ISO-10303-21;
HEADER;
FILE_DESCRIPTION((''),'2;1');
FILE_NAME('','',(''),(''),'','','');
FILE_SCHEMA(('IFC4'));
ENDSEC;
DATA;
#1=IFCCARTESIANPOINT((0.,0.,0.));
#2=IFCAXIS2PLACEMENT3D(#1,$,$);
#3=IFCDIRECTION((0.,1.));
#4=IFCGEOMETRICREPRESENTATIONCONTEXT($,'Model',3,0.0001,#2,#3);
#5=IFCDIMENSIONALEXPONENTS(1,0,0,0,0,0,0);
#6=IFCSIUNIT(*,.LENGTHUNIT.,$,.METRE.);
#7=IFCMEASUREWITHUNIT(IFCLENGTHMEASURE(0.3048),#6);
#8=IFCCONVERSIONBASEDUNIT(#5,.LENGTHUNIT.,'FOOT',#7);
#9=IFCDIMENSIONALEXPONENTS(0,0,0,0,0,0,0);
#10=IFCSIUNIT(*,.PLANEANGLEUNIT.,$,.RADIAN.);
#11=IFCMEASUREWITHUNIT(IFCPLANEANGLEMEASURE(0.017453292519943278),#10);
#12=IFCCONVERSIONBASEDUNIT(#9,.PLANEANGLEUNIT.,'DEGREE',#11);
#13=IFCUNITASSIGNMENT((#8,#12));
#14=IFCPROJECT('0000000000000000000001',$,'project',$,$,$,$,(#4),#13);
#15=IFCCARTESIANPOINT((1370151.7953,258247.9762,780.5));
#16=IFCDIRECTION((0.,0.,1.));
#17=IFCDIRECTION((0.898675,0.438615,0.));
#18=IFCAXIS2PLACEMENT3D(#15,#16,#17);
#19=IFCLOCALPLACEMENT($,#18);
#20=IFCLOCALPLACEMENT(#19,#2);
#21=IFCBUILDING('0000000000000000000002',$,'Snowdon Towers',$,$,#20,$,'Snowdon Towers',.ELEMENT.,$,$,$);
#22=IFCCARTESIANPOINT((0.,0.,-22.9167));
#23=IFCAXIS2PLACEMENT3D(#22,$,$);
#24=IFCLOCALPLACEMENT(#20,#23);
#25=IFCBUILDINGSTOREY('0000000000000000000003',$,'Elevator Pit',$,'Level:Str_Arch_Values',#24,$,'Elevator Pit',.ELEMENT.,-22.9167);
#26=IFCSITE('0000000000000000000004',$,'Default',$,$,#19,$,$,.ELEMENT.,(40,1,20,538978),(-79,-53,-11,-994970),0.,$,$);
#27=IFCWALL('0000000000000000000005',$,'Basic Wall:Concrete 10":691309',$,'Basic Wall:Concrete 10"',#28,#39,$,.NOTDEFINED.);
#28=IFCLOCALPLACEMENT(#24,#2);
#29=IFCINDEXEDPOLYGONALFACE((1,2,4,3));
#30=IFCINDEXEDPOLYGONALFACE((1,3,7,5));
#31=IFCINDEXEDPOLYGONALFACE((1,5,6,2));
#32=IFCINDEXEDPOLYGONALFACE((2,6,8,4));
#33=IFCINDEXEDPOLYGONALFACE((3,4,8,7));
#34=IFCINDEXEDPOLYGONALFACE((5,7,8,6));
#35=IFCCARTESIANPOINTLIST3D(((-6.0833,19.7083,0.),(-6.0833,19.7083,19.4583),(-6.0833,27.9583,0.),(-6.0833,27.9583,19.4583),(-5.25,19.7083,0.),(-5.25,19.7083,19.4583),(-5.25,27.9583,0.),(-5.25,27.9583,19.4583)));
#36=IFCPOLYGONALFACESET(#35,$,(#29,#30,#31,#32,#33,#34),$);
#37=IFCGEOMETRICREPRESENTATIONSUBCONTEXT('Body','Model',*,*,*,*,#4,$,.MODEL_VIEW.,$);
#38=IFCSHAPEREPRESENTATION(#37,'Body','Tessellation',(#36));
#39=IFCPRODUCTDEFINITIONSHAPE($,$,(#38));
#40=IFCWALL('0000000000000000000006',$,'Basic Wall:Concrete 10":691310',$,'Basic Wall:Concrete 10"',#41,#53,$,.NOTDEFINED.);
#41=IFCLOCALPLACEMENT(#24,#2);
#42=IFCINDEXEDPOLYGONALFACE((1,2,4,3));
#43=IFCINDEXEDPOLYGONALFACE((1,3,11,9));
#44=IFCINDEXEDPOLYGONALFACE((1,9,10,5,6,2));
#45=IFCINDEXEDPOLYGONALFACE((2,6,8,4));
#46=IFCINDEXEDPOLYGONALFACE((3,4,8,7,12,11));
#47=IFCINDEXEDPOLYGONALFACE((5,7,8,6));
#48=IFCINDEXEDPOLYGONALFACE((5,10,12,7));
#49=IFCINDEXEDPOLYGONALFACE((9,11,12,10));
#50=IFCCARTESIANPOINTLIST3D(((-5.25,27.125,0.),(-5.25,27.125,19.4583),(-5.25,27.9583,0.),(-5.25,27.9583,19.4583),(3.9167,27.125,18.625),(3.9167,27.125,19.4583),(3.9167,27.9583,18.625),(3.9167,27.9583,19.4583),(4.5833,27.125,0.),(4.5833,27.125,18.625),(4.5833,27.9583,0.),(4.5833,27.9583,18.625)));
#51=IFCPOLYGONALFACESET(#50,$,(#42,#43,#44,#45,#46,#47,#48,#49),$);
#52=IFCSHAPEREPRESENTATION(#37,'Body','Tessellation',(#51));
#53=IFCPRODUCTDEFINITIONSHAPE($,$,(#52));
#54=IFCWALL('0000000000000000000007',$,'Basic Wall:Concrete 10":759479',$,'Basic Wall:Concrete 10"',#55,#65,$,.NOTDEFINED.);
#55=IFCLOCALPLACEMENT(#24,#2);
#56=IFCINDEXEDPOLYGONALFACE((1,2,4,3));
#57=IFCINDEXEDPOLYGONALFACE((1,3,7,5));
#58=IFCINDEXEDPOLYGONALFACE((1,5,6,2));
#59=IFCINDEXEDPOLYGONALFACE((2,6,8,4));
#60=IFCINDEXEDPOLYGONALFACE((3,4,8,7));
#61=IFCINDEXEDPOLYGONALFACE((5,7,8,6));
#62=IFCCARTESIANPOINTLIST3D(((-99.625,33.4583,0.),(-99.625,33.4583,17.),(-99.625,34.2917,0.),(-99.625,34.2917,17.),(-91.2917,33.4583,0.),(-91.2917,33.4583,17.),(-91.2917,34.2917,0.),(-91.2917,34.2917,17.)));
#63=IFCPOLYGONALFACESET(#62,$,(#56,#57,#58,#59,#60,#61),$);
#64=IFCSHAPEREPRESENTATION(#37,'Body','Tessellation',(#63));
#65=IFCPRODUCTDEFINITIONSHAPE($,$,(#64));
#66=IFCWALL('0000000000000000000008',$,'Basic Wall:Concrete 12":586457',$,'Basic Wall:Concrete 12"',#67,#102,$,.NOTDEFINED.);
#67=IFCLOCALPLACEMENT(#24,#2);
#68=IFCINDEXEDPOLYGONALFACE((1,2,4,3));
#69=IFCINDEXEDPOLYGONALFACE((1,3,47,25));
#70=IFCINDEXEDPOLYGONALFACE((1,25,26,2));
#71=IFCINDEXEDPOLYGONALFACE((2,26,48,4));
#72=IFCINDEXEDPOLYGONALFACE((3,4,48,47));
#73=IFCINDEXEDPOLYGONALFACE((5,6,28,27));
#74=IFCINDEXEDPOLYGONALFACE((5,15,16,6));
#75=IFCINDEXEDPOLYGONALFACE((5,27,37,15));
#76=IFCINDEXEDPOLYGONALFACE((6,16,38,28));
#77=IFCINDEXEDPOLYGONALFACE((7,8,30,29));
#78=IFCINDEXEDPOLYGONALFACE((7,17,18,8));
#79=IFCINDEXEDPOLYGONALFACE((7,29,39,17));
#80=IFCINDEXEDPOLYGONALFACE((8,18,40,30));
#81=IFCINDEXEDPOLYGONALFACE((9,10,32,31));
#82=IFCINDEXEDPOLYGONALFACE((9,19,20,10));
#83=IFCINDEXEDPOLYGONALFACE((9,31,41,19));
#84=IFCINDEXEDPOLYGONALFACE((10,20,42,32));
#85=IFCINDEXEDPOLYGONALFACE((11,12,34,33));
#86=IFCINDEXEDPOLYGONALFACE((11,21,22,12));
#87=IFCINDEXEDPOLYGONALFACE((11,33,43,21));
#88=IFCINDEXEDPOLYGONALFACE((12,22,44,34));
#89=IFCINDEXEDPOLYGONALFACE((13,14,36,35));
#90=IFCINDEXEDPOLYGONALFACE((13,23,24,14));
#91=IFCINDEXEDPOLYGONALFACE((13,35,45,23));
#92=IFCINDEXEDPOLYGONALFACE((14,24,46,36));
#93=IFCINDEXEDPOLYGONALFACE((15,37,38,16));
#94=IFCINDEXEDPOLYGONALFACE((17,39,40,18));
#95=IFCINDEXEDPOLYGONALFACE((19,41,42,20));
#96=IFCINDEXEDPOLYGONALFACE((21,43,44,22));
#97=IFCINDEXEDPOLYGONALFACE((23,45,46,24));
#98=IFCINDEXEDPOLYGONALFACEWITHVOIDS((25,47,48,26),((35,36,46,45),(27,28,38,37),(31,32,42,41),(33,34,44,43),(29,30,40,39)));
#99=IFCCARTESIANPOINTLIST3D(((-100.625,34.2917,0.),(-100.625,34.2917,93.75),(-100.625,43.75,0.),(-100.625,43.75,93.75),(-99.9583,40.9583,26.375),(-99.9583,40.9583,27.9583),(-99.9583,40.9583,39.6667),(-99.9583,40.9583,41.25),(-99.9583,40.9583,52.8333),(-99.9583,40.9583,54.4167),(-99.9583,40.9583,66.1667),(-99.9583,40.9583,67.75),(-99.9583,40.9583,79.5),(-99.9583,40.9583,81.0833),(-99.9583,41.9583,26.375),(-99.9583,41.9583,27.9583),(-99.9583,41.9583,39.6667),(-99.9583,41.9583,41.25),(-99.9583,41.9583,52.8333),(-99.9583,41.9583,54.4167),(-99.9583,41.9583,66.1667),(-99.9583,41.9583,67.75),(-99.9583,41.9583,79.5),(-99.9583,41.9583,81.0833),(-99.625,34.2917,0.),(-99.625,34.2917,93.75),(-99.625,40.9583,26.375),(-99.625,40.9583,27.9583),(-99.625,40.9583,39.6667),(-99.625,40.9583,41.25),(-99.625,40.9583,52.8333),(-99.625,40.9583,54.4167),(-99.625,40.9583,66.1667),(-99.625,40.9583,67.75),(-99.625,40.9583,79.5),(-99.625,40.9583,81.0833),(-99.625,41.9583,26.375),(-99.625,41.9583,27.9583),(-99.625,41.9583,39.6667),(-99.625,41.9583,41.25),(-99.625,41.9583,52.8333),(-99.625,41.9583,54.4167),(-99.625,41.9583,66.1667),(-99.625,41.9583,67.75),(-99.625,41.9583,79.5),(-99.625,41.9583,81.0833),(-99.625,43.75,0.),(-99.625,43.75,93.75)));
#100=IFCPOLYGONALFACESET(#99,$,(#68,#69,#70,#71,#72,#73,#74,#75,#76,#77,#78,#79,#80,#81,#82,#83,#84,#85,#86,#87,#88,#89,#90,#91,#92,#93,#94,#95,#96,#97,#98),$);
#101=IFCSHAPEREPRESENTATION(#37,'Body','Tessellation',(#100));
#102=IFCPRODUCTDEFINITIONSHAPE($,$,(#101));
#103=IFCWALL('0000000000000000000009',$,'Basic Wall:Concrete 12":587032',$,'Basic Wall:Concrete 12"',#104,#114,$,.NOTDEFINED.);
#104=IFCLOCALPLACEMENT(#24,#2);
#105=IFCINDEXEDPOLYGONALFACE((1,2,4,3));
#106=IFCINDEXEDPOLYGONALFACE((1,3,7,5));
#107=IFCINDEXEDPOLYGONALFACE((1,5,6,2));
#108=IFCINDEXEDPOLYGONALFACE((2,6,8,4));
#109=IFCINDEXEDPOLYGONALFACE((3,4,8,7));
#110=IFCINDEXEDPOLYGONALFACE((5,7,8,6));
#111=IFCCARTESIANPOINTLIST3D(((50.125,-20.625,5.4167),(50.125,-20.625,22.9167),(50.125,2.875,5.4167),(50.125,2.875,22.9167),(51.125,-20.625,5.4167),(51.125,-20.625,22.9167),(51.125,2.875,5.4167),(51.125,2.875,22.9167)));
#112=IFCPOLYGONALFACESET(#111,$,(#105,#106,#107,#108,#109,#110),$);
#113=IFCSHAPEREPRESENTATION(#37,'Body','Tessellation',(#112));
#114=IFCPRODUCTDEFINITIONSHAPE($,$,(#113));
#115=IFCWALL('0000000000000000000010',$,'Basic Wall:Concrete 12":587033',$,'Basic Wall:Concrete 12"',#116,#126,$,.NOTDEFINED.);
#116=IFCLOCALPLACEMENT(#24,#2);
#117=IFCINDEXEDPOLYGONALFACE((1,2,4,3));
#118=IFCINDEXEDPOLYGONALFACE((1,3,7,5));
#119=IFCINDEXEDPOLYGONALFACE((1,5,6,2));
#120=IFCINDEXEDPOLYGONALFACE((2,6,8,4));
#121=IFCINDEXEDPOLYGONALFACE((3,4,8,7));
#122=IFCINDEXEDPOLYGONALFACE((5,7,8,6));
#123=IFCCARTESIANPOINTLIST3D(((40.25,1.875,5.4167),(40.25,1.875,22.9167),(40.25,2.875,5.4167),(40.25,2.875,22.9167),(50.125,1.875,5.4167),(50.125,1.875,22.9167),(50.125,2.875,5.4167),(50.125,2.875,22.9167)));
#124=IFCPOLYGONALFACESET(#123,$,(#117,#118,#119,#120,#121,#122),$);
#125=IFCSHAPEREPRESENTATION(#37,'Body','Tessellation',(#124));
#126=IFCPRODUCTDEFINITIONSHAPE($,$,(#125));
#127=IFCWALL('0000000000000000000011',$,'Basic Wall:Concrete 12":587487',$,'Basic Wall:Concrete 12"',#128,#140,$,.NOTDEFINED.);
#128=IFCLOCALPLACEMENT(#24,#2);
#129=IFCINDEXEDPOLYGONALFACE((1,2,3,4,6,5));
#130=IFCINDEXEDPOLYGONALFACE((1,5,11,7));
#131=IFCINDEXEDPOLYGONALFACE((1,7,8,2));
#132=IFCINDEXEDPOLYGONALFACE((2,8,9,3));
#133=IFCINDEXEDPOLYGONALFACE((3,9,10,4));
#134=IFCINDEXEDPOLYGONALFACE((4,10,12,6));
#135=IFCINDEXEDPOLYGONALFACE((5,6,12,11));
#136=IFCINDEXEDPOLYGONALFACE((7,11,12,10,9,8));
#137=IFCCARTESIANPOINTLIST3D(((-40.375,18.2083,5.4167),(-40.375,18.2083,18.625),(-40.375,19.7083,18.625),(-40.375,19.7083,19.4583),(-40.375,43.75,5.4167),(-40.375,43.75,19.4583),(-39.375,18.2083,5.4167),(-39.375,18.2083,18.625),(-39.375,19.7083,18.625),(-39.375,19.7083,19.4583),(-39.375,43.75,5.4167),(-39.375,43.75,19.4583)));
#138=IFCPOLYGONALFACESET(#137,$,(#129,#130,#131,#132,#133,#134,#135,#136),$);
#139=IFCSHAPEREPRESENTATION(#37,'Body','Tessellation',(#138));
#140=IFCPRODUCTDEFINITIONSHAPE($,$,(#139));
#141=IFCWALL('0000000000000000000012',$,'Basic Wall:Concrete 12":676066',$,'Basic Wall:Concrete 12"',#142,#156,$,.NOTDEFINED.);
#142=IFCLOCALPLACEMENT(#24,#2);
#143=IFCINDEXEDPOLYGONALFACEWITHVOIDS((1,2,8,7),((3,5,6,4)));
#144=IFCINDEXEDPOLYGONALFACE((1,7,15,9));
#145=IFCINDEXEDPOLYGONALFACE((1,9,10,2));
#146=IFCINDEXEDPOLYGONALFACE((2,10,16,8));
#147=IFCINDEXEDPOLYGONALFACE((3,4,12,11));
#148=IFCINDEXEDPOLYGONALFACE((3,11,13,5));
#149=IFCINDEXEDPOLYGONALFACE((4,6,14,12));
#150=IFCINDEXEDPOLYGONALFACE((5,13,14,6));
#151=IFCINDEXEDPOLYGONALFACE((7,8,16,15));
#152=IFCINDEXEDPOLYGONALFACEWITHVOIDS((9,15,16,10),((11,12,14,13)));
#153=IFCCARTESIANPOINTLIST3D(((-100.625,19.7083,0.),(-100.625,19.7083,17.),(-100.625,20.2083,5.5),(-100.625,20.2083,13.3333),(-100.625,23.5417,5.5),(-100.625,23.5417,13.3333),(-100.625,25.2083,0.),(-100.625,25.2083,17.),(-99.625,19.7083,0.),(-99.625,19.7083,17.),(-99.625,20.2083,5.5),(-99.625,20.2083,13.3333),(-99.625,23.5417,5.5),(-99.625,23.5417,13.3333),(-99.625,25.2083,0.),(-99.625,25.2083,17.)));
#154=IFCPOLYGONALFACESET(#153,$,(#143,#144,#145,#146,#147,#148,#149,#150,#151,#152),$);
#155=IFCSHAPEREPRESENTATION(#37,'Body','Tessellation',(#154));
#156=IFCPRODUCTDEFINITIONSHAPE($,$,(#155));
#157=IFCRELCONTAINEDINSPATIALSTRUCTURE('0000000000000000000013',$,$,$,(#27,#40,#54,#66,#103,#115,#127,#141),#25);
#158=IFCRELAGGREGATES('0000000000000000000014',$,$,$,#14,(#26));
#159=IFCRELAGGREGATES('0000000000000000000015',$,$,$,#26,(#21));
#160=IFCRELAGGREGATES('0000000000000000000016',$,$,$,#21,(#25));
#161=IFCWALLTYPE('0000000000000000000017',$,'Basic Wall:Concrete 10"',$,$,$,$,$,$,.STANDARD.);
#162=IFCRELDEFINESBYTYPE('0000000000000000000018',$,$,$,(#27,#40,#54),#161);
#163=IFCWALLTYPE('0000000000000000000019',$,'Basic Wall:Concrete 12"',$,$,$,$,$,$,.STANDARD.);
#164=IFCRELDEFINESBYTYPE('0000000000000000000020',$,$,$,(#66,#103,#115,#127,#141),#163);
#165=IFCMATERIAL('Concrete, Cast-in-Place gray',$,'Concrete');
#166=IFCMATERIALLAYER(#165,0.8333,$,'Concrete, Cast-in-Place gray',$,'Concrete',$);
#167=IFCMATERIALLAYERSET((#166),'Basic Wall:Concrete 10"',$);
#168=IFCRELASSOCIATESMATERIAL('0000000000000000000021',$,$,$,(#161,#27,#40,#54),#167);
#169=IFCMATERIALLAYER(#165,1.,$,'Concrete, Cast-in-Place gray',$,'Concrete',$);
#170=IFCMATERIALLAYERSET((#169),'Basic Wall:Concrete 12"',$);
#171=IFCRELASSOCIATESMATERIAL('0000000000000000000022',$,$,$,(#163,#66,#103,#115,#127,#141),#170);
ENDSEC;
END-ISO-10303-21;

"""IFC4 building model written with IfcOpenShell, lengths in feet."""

from ifc_helpers import new_model, entity, si_unit, converted_unit, direction, frame, frame_2d, origin, origin_2d_with_axis, place, context, subcontext, project, spatial, polyline, rectangle, extrude, clip, bounded_halfspace, material, layer, layer_set, layer_usage, type_object, element, save


model = new_model("IFC4")

# Units and contexts
model_context = context("Model", 3, precision=0.0001, world=origin(), true_north=direction((0.0, 1.0)))
body_context = subcontext(model_context, "Body", "Model", "MODEL_VIEW")
ifc_project = project(units=[converted_unit("LENGTHUNIT", "FOOT", entity("IfcLengthMeasure", 0.3048), si_unit("LENGTHUNIT", "METRE"), dimensions=[1, 0, 0, 0, 0, 0, 0]), converted_unit("PLANEANGLEUNIT", "DEGREE", entity("IfcPlaneAngleMeasure", 0.017453292519943278), si_unit("PLANEANGLEUNIT", "RADIAN"), dimensions=[0, 0, 0, 0, 0, 0, 0])], contexts=[model_context])

# Site, building, storey
site_placement = place(None, frame((1370151.7953, 258247.9762, 780.5), z_axis=(0.0, 0.0, 1.0), x_axis=(0.898675, 0.438615, 0.0)))
site = spatial("IfcSite", under=ifc_project, at=site_placement, Name="Default", CompositionType="ELEMENT", RefLatitude=(40, 1, 20, 538978), RefLongitude=(-79, -53, -11, -994970), RefElevation=0.0)
building_placement = place(site_placement, origin())
building = spatial("IfcBuilding", under=site, at=building_placement, Name="Snowdon Towers", LongName="Snowdon Towers", CompositionType="ELEMENT")
storey_placement = place(building_placement, frame((0.0, 0.0, -22.9167)))
storey = spatial("IfcBuildingStorey", under=building, at=storey_placement, Name="Elevator Pit", ObjectType="Level:Str_Arch_Values", LongName="Elevator Pit", CompositionType="ELEMENT", Elevation=-22.9167)

# Shared definitions
ifc_material = material(Name="Concrete, Cast-in-Place gray", Category="Concrete")
ifc_layer_1 = layer(ifc_material, 0.8333, Name="Concrete, Cast-in-Place gray", Category="Concrete")
ifc_layer_set_1 = layer_set([ifc_layer_1], Name="Basic Wall:Concrete 10\"")
wall_type_1 = type_object("IfcWallType", Name="Basic Wall:Concrete 10\"", PredefinedType="STANDARD", material=ifc_layer_set_1)

# Walls
ifc_layer_usage_1 = layer_usage(ifc_layer_set_1, "AXIS2", "NEGATIVE", 0.4167)
wall_1_placement = place(storey_placement, frame((-5.6667, 27.9583, 0.0), z_axis=(0.0, 0.0, 1.0), x_axis=(0.0, -1.0, 0.0)))
element("IfcWall", 1, at=wall_1_placement, inside=storey, type_object=wall_type_1, material=ifc_layer_usage_1, Name="Basic Wall:Concrete 10\":691309", ObjectType="Basic Wall:Concrete 10\"", PredefinedType="NOTDEFINED", context=body_context, shape_type="SweptSolid", body=[
    extrude(rectangle(XDim=8.25, YDim=0.8333, at=frame_2d((4.125, 0.0), x_axis=(-1.0, 0.0))), origin(), (0.0, 0.0, 1.0), 19.4583),
])
ifc_layer_usage_2 = layer_usage(ifc_layer_set_1, "AXIS2", "NEGATIVE", 0.4167)
wall_2_placement = place(storey_placement, frame((4.5833, 27.5417, 0.0), z_axis=(0.0, 0.0, 1.0), x_axis=(-1.0, 0.0, 0.0)))
element("IfcWall", 2, at=wall_2_placement, inside=storey, type_object=wall_type_1, material=ifc_layer_usage_2, Name="Basic Wall:Concrete 10\":691310", ObjectType="Basic Wall:Concrete 10\"", PredefinedType="NOTDEFINED", context=body_context, shape_type="Clipping", body=[
    clip(clip(extrude(rectangle(XDim=9.8333, YDim=0.8333, at=frame_2d((4.9167, 0.0), x_axis=(-1.0, 0.0))), origin(), (0.0, 0.0, 1.0), 19.4583), bounded_halfspace(frame((0.6667, -0.4167, 18.625), z_axis=(0.0, 0.0, -1.0), x_axis=(1.0, 0.0, 0.0)), True, frame((0.6667, -0.4167, 18.625), z_axis=(0.0, 0.0, -1.0), x_axis=(1.0, 0.0, 0.0)), polyline([(0.0, 0.0), (-0.6667, 0.0), (-0.6667, -0.8333), (0.0, -0.8333), (0.0, 0.0)]))), bounded_halfspace(frame((0.6667, 0.4167, 18.625), z_axis=(1.0, 0.0, 0.0), x_axis=(0.0, 0.0, 1.0)), True, frame((0.6667, 0.4167, 18.625), z_axis=(1.0, 0.0, 0.0), x_axis=(0.0, 0.0, 1.0)), polyline([(0.0, 0.0), (0.8333, 0.0), (0.8333, 0.8333), (0.0, 0.8333), (0.0, 0.0)]))),
])
ifc_layer_usage_3 = layer_usage(ifc_layer_set_1, "AXIS2", "POSITIVE", -0.4167)
wall_3_placement = place(storey_placement, frame((-99.625, 33.875, 0.0)))
element("IfcWall", 3, at=wall_3_placement, inside=storey, type_object=wall_type_1, material=ifc_layer_usage_3, Name="Basic Wall:Concrete 10\":759479", ObjectType="Basic Wall:Concrete 10\"", PredefinedType="NOTDEFINED", context=body_context, shape_type="SweptSolid", body=[
    extrude(rectangle(XDim=8.3333, YDim=0.8333, at=frame_2d((4.1667, 0.0), x_axis=(-1.0, 0.0))), origin(), (0.0, 0.0, 1.0), 17.0),
])

# Wall, openings
ifc_layer_2 = layer(ifc_material, 1.0, Name="Concrete, Cast-in-Place gray", Category="Concrete")
ifc_layer_set_2 = layer_set([ifc_layer_2], Name="Basic Wall:Concrete 12\"")
ifc_layer_usage_4 = layer_usage(ifc_layer_set_2, "AXIS2", "NEGATIVE", 0.5)
wall_type_2 = type_object("IfcWallType", Name="Basic Wall:Concrete 12\"", PredefinedType="STANDARD", material=ifc_layer_set_2)
wall_4_placement = place(storey_placement, frame((-100.125, 34.2917, 0.0), z_axis=(0.0, 0.0, 1.0), x_axis=(0.0, 1.0, 0.0)))
wall_4 = element("IfcWall", 4, at=wall_4_placement, inside=storey, type_object=wall_type_2, material=ifc_layer_usage_4, Name="Basic Wall:Concrete 12\":586457", ObjectType="Basic Wall:Concrete 12\"", PredefinedType="NOTDEFINED", context=body_context, shape_type="SweptSolid", body=[
    extrude(rectangle(XDim=9.4583, YDim=1.0, at=frame_2d((4.7292, 0.0), x_axis=(-1.0, 0.0))), origin(), (0.0, 0.0, 1.0), 93.75),
])
opening_1_placement = place(wall_4_placement, origin())
element("IfcOpeningElement", 5, at=opening_1_placement, cuts=wall_4, PredefinedType="RECESS", context=body_context, shape_type="SweptSolid", body=[
    extrude(rectangle(XDim=1.5833, YDim=1.0, at=frame_2d((0.0, 0.0), x_axis=(1.0, 0.0))), frame((7.1667, -0.5, 40.4583), z_axis=(0.0, 1.0, 0.0), x_axis=(0.0, 0.0, -1.0)), (0.0, 0.0, 1.0), 0.3333),
])
opening_2_placement = place(wall_4_placement, origin())
element("IfcOpeningElement", 6, at=opening_2_placement, cuts=wall_4, PredefinedType="RECESS", context=body_context, shape_type="SweptSolid", body=[
    extrude(rectangle(XDim=1.5833, YDim=1.0, at=frame_2d((0.0, 0.0), x_axis=(1.0, 0.0))), frame((7.1667, -0.5, 27.1667), z_axis=(0.0, 1.0, 0.0), x_axis=(0.0, 0.0, -1.0)), (0.0, 0.0, 1.0), 0.3333),
])
opening_3_placement = place(wall_4_placement, origin())
element("IfcOpeningElement", 7, at=opening_3_placement, cuts=wall_4, PredefinedType="RECESS", context=body_context, shape_type="SweptSolid", body=[
    extrude(rectangle(XDim=1.5833, YDim=1.0, at=frame_2d((0.0, 0.0), x_axis=(1.0, 0.0))), frame((7.1667, -0.5, 80.2917), z_axis=(0.0, 1.0, 0.0), x_axis=(0.0, 0.0, -1.0)), (0.0, 0.0, 1.0), 0.3333),
])
opening_4_placement = place(wall_4_placement, origin())
element("IfcOpeningElement", 8, at=opening_4_placement, cuts=wall_4, PredefinedType="RECESS", context=body_context, shape_type="SweptSolid", body=[
    extrude(rectangle(XDim=1.5833, YDim=1.0, at=frame_2d((0.0, 0.0), x_axis=(1.0, 0.0))), frame((7.1667, -0.5, 53.625), z_axis=(0.0, 1.0, 0.0), x_axis=(0.0, 0.0, -1.0)), (0.0, 0.0, 1.0), 0.3333),
])
opening_5_placement = place(wall_4_placement, origin())
element("IfcOpeningElement", 9, at=opening_5_placement, cuts=wall_4, PredefinedType="RECESS", context=body_context, shape_type="SweptSolid", body=[
    extrude(rectangle(XDim=1.5833, YDim=1.0, at=origin_2d_with_axis()), frame((7.1667, -0.5, 66.9583), z_axis=(0.0, 1.0, 0.0), x_axis=(0.0, 0.0, -1.0)), (0.0, 0.0, 1.0), 0.3333),
])

# Walls
ifc_layer_usage_5 = layer_usage(ifc_layer_set_2, "AXIS2", "NEGATIVE", 0.5)
wall_5_placement = place(storey_placement, frame((50.625, -20.625, 5.4167), z_axis=(0.0, 0.0, 1.0), x_axis=(0.0, 1.0, 0.0)))
element("IfcWall", 10, at=wall_5_placement, inside=storey, type_object=wall_type_2, material=ifc_layer_usage_5, Name="Basic Wall:Concrete 12\":587032", ObjectType="Basic Wall:Concrete 12\"", PredefinedType="NOTDEFINED", context=body_context, shape_type="SweptSolid", body=[
    extrude(rectangle(XDim=23.5, YDim=1.0, at=frame_2d((11.75, 0.0), x_axis=(-1.0, 0.0))), origin(), (0.0, 0.0, 1.0), 17.5),
])
ifc_layer_usage_6 = layer_usage(ifc_layer_set_2, "AXIS2", "NEGATIVE", 0.5)
wall_6_placement = place(storey_placement, frame((50.125, 2.375, 5.4167), z_axis=(0.0, 0.0, 1.0), x_axis=(-1.0, 0.0, 0.0)))
element("IfcWall", 11, at=wall_6_placement, inside=storey, type_object=wall_type_2, material=ifc_layer_usage_6, Name="Basic Wall:Concrete 12\":587033", ObjectType="Basic Wall:Concrete 12\"", PredefinedType="NOTDEFINED", context=body_context, shape_type="SweptSolid", body=[
    extrude(rectangle(XDim=9.875, YDim=1.0, at=frame_2d((4.9375, 0.0), x_axis=(-1.0, 0.0))), origin(), (0.0, 0.0, 1.0), 17.5),
])
ifc_layer_usage_7 = layer_usage(ifc_layer_set_2, "AXIS2", "NEGATIVE", 0.5)
wall_7_placement = place(storey_placement, frame((-39.875, 18.2083, 5.4167), z_axis=(0.0, 0.0, 1.0), x_axis=(0.0, 1.0, 0.0)))
element("IfcWall", 12, at=wall_7_placement, inside=storey, type_object=wall_type_2, material=ifc_layer_usage_7, Name="Basic Wall:Concrete 12\":587487", ObjectType="Basic Wall:Concrete 12\"", PredefinedType="NOTDEFINED", context=body_context, shape_type="Clipping", body=[
    clip(clip(extrude(rectangle(XDim=25.5417, YDim=1.0, at=frame_2d((12.7708, 0.0), x_axis=(-1.0, 0.0))), origin(), (0.0, 0.0, 1.0), 14.0417), bounded_halfspace(frame((1.5, -0.5, 13.2083), z_axis=(0.0, 0.0, -1.0), x_axis=(0.0, 1.0, 0.0)), True, frame((1.5, -0.5, 13.2083), z_axis=(0.0, 0.0, -1.0), x_axis=(0.0, 1.0, 0.0)), polyline([(0.0, 0.0), (0.0, -1.5), (1.0, -1.5), (1.0, 0.0), (0.0, 0.0)]))), bounded_halfspace(frame((1.5, 0.5, 13.2083), z_axis=(1.0, 0.0, 0.0), x_axis=(0.0, 0.0, 1.0)), True, frame((1.5, 0.5, 13.2083), z_axis=(1.0, 0.0, 0.0), x_axis=(0.0, 0.0, 1.0)), polyline([(0.0, 0.0), (0.8333, 0.0), (0.8333, 1.0), (0.0, 1.0), (0.0, 0.0)]))),
])

# Wall, opening
ifc_layer_usage_8 = layer_usage(ifc_layer_set_2, "AXIS2", "POSITIVE", -0.5)
wall_8_placement = place(storey_placement, frame((-100.125, 25.2083, 0.0), z_axis=(0.0, 0.0, 1.0), x_axis=(0.0, -1.0, 0.0)))
wall_8 = element("IfcWall", 13, at=wall_8_placement, inside=storey, type_object=wall_type_2, material=ifc_layer_usage_8, Name="Basic Wall:Concrete 12\":676066", ObjectType="Basic Wall:Concrete 12\"", PredefinedType="NOTDEFINED", context=body_context, shape_type="SweptSolid", body=[
    extrude(rectangle(XDim=5.5, YDim=1.0, at=frame_2d((2.75, 0.0), x_axis=(-1.0, 0.0))), origin(), (0.0, 0.0, 1.0), 17.0),
])
opening_6_placement = place(wall_8_placement, origin())
element("IfcOpeningElement", 14, at=opening_6_placement, cuts=wall_8, PredefinedType="OPENING", context=body_context, shape_type="SweptSolid", body=[
    extrude(rectangle(XDim=7.8333, YDim=3.3333, at=frame_2d((0.0, 0.0), x_axis=(1.0, 0.0))), frame((3.3333, -4.5, 9.4167), z_axis=(0.0, 1.0, 0.0), x_axis=(0.0, 0.0, 1.0)), (0.0, 0.0, 1.0), 10.0),
])

save(model, "model.ifc")
